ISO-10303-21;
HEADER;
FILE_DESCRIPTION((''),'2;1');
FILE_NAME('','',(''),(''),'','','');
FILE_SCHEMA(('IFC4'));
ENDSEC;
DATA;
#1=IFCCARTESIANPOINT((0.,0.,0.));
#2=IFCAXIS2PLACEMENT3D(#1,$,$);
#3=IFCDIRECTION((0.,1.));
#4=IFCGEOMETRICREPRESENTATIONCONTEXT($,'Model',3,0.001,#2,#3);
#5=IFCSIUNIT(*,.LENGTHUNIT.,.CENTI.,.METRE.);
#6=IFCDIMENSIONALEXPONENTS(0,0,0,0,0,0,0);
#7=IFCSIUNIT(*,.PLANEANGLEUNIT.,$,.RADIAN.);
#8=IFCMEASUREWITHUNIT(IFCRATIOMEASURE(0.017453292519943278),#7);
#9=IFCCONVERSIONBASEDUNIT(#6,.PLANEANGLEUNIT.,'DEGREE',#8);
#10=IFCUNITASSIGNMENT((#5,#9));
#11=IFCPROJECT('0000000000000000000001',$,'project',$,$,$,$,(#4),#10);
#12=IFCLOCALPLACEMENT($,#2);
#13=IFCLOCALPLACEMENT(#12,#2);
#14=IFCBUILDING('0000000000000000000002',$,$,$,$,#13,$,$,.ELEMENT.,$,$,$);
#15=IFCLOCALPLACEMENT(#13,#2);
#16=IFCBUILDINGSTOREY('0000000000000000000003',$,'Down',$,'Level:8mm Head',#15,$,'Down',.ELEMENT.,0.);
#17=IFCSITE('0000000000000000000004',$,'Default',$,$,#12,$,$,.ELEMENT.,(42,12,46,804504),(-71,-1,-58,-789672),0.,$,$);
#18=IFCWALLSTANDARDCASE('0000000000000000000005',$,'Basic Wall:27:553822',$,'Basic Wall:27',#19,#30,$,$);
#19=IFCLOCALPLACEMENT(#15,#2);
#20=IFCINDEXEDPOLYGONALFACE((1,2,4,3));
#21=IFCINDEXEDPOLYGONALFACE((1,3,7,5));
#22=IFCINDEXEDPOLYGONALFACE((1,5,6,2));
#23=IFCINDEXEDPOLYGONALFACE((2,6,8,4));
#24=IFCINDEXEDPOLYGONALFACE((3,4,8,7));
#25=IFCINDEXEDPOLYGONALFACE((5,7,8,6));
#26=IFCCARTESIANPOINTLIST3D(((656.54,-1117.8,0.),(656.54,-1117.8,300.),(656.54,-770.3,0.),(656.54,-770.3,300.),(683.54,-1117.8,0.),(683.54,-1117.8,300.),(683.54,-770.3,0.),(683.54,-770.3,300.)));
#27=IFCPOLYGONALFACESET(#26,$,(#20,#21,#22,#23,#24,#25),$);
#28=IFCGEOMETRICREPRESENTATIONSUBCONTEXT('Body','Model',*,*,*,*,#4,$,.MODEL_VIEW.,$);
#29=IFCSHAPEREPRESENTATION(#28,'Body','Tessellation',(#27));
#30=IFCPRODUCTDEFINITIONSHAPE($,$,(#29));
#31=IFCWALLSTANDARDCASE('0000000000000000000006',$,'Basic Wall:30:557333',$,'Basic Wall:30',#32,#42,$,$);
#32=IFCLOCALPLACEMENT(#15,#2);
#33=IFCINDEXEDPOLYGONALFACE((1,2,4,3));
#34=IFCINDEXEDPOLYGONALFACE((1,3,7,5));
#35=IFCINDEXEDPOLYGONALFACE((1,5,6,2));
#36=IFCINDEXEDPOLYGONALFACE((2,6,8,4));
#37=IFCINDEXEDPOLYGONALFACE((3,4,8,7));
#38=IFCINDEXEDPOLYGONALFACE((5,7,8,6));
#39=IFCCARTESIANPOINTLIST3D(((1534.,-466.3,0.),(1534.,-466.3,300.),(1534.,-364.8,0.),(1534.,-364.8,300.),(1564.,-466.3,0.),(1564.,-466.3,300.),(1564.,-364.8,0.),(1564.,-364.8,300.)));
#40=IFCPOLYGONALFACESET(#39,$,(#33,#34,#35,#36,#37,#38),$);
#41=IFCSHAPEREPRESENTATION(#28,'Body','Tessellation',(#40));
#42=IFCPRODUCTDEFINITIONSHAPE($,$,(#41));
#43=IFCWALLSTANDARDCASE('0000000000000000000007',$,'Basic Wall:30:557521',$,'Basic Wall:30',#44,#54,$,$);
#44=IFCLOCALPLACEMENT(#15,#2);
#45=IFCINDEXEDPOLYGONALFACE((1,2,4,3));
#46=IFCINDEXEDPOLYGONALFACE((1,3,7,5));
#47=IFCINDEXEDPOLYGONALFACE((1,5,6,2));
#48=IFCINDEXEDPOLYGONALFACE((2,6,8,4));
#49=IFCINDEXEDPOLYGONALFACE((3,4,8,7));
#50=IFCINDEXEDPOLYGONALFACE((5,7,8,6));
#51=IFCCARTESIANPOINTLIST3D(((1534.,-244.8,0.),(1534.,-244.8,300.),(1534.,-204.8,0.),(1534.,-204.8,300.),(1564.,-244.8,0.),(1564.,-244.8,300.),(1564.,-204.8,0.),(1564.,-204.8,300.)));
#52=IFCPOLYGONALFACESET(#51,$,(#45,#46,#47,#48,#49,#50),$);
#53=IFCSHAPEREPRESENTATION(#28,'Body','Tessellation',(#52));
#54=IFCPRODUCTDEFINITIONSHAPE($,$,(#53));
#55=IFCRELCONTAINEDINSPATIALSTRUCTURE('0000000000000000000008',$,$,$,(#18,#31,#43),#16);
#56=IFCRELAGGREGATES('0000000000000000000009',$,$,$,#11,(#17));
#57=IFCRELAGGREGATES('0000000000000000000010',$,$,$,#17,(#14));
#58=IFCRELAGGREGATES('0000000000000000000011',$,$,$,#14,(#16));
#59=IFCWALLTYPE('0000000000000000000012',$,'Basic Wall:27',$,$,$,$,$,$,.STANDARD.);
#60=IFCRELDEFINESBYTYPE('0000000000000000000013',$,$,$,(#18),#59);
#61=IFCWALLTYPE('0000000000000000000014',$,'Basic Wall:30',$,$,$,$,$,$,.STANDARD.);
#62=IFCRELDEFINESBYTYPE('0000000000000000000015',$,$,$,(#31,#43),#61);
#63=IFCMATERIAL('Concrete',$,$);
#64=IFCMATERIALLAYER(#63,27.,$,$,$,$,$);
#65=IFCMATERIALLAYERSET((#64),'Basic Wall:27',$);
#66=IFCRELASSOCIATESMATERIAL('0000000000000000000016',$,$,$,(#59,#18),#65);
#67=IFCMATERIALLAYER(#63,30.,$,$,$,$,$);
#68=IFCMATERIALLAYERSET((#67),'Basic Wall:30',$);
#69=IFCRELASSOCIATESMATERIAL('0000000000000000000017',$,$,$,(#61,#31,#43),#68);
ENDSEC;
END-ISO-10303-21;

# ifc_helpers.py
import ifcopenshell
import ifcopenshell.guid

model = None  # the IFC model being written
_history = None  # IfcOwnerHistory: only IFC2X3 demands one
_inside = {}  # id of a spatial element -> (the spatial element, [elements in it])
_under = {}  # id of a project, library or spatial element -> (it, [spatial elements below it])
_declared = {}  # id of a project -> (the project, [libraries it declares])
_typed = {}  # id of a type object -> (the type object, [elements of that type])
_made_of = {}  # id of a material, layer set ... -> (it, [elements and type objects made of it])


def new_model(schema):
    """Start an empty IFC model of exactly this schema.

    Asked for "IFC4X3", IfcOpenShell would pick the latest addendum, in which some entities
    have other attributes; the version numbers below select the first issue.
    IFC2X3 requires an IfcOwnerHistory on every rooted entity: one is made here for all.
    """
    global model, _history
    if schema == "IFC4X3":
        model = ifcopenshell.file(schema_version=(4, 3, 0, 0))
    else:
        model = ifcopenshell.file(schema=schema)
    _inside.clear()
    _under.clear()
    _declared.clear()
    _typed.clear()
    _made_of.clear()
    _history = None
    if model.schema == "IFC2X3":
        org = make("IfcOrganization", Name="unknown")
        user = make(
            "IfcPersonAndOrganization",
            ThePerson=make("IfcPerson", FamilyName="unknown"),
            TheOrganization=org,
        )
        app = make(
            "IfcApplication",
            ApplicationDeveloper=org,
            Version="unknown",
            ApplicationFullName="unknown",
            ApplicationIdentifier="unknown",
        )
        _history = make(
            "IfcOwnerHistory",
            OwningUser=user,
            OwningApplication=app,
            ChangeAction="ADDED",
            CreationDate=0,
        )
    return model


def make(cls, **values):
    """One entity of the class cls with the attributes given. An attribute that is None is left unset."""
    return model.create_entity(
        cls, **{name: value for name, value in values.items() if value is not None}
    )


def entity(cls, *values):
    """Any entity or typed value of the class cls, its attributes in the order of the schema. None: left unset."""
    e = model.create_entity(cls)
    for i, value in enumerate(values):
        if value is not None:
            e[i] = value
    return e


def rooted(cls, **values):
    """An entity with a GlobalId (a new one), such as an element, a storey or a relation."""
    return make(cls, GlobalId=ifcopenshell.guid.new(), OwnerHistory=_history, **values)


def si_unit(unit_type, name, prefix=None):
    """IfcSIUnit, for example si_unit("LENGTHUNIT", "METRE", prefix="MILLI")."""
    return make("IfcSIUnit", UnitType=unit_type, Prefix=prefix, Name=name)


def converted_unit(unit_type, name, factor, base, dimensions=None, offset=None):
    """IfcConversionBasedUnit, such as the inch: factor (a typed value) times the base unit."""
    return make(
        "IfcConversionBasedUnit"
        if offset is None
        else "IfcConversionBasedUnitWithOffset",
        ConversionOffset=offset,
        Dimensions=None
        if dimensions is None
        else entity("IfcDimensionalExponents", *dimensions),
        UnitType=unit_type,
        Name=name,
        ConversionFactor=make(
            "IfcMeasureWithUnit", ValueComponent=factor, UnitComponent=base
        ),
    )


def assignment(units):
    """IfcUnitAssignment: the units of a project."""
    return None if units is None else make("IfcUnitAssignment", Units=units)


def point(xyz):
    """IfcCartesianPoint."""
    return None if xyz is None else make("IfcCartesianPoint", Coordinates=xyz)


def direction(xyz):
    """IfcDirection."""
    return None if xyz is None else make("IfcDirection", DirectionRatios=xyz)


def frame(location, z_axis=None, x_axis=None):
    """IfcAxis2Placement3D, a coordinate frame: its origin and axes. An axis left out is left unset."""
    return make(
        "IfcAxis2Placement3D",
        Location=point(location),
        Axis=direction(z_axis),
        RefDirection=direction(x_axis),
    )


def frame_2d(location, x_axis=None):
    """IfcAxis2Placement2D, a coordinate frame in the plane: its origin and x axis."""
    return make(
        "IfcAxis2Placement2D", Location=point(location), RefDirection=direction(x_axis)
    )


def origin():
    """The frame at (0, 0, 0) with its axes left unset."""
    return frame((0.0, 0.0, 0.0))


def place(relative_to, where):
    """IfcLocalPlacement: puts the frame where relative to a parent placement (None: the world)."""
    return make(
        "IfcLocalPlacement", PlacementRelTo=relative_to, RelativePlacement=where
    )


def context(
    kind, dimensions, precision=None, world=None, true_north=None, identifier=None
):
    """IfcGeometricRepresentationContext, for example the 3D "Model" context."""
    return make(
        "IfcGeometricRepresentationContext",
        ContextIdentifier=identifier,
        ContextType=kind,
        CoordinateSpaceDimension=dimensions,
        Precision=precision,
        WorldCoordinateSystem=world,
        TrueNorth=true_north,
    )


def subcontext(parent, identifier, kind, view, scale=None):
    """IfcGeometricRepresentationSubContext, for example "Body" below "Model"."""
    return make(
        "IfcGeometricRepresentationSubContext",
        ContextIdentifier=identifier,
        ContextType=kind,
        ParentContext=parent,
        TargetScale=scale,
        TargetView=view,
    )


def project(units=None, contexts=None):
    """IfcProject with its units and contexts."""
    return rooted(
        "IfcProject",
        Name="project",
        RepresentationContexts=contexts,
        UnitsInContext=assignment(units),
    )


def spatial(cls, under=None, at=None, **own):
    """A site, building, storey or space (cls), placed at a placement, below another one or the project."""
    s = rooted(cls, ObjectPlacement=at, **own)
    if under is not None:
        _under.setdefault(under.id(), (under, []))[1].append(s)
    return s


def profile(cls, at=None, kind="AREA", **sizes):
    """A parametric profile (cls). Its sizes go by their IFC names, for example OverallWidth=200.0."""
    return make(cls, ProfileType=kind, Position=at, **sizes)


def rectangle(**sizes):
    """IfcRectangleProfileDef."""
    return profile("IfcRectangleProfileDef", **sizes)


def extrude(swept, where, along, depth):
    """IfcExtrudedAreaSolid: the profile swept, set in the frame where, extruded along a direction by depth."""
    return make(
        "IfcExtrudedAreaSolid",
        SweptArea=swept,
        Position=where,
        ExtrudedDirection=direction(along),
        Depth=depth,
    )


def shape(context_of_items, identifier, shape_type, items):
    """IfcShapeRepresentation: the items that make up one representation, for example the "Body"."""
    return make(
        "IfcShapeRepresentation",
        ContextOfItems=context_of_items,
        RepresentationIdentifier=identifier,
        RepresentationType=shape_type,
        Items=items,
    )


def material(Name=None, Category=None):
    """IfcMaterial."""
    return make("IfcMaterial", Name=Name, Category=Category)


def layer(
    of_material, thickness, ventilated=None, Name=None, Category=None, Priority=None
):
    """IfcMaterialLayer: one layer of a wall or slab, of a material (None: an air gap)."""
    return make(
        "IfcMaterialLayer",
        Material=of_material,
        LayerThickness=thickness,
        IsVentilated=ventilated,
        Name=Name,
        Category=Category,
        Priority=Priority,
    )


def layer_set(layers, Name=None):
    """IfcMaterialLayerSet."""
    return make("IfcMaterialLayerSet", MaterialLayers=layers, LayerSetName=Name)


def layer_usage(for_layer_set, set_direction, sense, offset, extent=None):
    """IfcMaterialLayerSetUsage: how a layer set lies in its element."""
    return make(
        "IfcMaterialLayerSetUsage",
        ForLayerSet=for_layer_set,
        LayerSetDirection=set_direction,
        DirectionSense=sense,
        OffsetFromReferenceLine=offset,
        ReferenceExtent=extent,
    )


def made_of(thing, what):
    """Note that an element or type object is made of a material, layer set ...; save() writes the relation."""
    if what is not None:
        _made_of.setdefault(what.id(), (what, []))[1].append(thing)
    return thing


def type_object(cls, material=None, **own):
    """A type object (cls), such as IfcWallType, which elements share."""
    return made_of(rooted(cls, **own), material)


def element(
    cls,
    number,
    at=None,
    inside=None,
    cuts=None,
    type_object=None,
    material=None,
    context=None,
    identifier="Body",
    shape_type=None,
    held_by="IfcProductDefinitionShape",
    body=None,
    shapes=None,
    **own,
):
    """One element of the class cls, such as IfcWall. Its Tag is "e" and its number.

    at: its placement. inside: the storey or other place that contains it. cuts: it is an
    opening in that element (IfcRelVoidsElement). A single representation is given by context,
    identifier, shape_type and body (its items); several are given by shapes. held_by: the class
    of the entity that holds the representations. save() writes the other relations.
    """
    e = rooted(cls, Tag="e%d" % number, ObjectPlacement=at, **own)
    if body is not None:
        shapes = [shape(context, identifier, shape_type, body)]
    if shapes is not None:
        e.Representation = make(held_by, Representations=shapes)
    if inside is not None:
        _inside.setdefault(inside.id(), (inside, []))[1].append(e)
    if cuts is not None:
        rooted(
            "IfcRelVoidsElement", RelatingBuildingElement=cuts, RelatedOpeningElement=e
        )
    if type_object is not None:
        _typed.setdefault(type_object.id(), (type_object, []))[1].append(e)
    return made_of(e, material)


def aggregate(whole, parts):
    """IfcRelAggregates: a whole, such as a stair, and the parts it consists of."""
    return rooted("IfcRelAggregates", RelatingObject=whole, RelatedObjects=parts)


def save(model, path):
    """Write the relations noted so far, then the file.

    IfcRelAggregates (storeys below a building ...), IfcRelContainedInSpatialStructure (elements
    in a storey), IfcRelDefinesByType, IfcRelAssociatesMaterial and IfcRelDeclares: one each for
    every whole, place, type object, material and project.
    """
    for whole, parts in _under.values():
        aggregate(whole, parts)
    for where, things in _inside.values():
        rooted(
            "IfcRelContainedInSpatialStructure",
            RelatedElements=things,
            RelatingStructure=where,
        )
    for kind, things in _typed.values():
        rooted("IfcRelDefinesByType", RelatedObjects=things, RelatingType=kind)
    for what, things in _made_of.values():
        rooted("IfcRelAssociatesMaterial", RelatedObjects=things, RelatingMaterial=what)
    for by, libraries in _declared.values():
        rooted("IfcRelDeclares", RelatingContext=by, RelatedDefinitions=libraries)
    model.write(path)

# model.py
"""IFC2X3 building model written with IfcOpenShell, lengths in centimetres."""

from ifc_helpers import new_model, entity, si_unit, converted_unit, direction, frame, frame_2d, origin, place, context, subcontext, project, spatial, rectangle, extrude, material, layer, layer_set, layer_usage, type_object, element, save


model = new_model("IFC2X3")

# Units and contexts
model_context = context("Model", 3, precision=0.001, world=origin(), true_north=direction((0.0, 1.0)))
body_context = subcontext(model_context, "Body", "Model", "MODEL_VIEW")
ifc_project = project(units=[si_unit("LENGTHUNIT", "METRE", prefix="CENTI"), converted_unit("PLANEANGLEUNIT", "DEGREE", entity("IfcRatioMeasure", 0.017453292519943278), si_unit("PLANEANGLEUNIT", "RADIAN"), dimensions=[0, 0, 0, 0, 0, 0, 0])], contexts=[model_context])

# Site, building, storey
site_placement = place(None, origin())
site = spatial("IfcSite", under=ifc_project, at=site_placement, Name="Default", CompositionType="ELEMENT", RefLatitude=(42, 12, 46, 804504), RefLongitude=(-71, -1, -58, -789672), RefElevation=0.0)
building_placement = place(site_placement, origin())
building = spatial("IfcBuilding", under=site, at=building_placement, CompositionType="ELEMENT")
storey_placement = place(building_placement, origin())
storey = spatial("IfcBuildingStorey", under=building, at=storey_placement, Name="Down", ObjectType="Level:8mm Head", LongName="Down", CompositionType="ELEMENT", Elevation=0.0)

# Walls
ifc_material = material(Name="Concrete")
ifc_layer_1 = layer(ifc_material, 27.0)
ifc_layer_set_1 = layer_set([ifc_layer_1], Name="Basic Wall:27")
ifc_layer_usage_1 = layer_usage(ifc_layer_set_1, "AXIS2", "NEGATIVE", 13.5)
wall_type_1 = type_object("IfcWallType", Name="Basic Wall:27", PredefinedType="STANDARD", material=ifc_layer_set_1)
wall_1_placement = place(storey_placement, frame((670.04, -770.3, 0.0), z_axis=(0.0, 0.0, 1.0), x_axis=(0.0, -1.0, 0.0)))
element("IfcWallStandardCase", 1, at=wall_1_placement, inside=storey, type_object=wall_type_1, material=ifc_layer_usage_1, Name="Basic Wall:27:553822", ObjectType="Basic Wall:27", context=body_context, shape_type="SweptSolid", body=[
    extrude(rectangle(XDim=347.5, YDim=27.0, at=frame_2d((173.75, 0.0), x_axis=(-1.0, 0.0))), origin(), (0.0, 0.0, 1.0), 300.0),
])
ifc_layer_2 = layer(ifc_material, 30.0)
ifc_layer_set_2 = layer_set([ifc_layer_2], Name="Basic Wall:30")
ifc_layer_usage_2 = layer_usage(ifc_layer_set_2, "AXIS2", "NEGATIVE", 15.0)
wall_type_2 = type_object("IfcWallType", Name="Basic Wall:30", PredefinedType="STANDARD", material=ifc_layer_set_2)
wall_2_placement = place(storey_placement, frame((1549.0, -466.3, 0.0), z_axis=(0.0, 0.0, 1.0), x_axis=(0.0, 1.0, 0.0)))
element("IfcWallStandardCase", 2, at=wall_2_placement, inside=storey, type_object=wall_type_2, material=ifc_layer_usage_2, Name="Basic Wall:30:557333", ObjectType="Basic Wall:30", context=body_context, shape_type="SweptSolid", body=[
    extrude(rectangle(XDim=101.5, YDim=30.0, at=frame_2d((50.75, 0.0), x_axis=(-1.0, 0.0))), origin(), (0.0, 0.0, 1.0), 300.0),
])
ifc_layer_usage_3 = layer_usage(ifc_layer_set_2, "AXIS2", "NEGATIVE", 15.0)
wall_3_placement = place(storey_placement, frame((1549.0, -244.8, 0.0), z_axis=(0.0, 0.0, 1.0), x_axis=(0.0, 1.0, 0.0)))
element("IfcWallStandardCase", 3, at=wall_3_placement, inside=storey, type_object=wall_type_2, material=ifc_layer_usage_3, Name="Basic Wall:30:557521", ObjectType="Basic Wall:30", context=body_context, shape_type="SweptSolid", body=[
    extrude(rectangle(XDim=40.0, YDim=30.0, at=frame_2d((20.0, 0.0), x_axis=(-1.0, 0.0))), origin(), (0.0, 0.0, 1.0), 300.0),
])

save(model, "model.ifc")
